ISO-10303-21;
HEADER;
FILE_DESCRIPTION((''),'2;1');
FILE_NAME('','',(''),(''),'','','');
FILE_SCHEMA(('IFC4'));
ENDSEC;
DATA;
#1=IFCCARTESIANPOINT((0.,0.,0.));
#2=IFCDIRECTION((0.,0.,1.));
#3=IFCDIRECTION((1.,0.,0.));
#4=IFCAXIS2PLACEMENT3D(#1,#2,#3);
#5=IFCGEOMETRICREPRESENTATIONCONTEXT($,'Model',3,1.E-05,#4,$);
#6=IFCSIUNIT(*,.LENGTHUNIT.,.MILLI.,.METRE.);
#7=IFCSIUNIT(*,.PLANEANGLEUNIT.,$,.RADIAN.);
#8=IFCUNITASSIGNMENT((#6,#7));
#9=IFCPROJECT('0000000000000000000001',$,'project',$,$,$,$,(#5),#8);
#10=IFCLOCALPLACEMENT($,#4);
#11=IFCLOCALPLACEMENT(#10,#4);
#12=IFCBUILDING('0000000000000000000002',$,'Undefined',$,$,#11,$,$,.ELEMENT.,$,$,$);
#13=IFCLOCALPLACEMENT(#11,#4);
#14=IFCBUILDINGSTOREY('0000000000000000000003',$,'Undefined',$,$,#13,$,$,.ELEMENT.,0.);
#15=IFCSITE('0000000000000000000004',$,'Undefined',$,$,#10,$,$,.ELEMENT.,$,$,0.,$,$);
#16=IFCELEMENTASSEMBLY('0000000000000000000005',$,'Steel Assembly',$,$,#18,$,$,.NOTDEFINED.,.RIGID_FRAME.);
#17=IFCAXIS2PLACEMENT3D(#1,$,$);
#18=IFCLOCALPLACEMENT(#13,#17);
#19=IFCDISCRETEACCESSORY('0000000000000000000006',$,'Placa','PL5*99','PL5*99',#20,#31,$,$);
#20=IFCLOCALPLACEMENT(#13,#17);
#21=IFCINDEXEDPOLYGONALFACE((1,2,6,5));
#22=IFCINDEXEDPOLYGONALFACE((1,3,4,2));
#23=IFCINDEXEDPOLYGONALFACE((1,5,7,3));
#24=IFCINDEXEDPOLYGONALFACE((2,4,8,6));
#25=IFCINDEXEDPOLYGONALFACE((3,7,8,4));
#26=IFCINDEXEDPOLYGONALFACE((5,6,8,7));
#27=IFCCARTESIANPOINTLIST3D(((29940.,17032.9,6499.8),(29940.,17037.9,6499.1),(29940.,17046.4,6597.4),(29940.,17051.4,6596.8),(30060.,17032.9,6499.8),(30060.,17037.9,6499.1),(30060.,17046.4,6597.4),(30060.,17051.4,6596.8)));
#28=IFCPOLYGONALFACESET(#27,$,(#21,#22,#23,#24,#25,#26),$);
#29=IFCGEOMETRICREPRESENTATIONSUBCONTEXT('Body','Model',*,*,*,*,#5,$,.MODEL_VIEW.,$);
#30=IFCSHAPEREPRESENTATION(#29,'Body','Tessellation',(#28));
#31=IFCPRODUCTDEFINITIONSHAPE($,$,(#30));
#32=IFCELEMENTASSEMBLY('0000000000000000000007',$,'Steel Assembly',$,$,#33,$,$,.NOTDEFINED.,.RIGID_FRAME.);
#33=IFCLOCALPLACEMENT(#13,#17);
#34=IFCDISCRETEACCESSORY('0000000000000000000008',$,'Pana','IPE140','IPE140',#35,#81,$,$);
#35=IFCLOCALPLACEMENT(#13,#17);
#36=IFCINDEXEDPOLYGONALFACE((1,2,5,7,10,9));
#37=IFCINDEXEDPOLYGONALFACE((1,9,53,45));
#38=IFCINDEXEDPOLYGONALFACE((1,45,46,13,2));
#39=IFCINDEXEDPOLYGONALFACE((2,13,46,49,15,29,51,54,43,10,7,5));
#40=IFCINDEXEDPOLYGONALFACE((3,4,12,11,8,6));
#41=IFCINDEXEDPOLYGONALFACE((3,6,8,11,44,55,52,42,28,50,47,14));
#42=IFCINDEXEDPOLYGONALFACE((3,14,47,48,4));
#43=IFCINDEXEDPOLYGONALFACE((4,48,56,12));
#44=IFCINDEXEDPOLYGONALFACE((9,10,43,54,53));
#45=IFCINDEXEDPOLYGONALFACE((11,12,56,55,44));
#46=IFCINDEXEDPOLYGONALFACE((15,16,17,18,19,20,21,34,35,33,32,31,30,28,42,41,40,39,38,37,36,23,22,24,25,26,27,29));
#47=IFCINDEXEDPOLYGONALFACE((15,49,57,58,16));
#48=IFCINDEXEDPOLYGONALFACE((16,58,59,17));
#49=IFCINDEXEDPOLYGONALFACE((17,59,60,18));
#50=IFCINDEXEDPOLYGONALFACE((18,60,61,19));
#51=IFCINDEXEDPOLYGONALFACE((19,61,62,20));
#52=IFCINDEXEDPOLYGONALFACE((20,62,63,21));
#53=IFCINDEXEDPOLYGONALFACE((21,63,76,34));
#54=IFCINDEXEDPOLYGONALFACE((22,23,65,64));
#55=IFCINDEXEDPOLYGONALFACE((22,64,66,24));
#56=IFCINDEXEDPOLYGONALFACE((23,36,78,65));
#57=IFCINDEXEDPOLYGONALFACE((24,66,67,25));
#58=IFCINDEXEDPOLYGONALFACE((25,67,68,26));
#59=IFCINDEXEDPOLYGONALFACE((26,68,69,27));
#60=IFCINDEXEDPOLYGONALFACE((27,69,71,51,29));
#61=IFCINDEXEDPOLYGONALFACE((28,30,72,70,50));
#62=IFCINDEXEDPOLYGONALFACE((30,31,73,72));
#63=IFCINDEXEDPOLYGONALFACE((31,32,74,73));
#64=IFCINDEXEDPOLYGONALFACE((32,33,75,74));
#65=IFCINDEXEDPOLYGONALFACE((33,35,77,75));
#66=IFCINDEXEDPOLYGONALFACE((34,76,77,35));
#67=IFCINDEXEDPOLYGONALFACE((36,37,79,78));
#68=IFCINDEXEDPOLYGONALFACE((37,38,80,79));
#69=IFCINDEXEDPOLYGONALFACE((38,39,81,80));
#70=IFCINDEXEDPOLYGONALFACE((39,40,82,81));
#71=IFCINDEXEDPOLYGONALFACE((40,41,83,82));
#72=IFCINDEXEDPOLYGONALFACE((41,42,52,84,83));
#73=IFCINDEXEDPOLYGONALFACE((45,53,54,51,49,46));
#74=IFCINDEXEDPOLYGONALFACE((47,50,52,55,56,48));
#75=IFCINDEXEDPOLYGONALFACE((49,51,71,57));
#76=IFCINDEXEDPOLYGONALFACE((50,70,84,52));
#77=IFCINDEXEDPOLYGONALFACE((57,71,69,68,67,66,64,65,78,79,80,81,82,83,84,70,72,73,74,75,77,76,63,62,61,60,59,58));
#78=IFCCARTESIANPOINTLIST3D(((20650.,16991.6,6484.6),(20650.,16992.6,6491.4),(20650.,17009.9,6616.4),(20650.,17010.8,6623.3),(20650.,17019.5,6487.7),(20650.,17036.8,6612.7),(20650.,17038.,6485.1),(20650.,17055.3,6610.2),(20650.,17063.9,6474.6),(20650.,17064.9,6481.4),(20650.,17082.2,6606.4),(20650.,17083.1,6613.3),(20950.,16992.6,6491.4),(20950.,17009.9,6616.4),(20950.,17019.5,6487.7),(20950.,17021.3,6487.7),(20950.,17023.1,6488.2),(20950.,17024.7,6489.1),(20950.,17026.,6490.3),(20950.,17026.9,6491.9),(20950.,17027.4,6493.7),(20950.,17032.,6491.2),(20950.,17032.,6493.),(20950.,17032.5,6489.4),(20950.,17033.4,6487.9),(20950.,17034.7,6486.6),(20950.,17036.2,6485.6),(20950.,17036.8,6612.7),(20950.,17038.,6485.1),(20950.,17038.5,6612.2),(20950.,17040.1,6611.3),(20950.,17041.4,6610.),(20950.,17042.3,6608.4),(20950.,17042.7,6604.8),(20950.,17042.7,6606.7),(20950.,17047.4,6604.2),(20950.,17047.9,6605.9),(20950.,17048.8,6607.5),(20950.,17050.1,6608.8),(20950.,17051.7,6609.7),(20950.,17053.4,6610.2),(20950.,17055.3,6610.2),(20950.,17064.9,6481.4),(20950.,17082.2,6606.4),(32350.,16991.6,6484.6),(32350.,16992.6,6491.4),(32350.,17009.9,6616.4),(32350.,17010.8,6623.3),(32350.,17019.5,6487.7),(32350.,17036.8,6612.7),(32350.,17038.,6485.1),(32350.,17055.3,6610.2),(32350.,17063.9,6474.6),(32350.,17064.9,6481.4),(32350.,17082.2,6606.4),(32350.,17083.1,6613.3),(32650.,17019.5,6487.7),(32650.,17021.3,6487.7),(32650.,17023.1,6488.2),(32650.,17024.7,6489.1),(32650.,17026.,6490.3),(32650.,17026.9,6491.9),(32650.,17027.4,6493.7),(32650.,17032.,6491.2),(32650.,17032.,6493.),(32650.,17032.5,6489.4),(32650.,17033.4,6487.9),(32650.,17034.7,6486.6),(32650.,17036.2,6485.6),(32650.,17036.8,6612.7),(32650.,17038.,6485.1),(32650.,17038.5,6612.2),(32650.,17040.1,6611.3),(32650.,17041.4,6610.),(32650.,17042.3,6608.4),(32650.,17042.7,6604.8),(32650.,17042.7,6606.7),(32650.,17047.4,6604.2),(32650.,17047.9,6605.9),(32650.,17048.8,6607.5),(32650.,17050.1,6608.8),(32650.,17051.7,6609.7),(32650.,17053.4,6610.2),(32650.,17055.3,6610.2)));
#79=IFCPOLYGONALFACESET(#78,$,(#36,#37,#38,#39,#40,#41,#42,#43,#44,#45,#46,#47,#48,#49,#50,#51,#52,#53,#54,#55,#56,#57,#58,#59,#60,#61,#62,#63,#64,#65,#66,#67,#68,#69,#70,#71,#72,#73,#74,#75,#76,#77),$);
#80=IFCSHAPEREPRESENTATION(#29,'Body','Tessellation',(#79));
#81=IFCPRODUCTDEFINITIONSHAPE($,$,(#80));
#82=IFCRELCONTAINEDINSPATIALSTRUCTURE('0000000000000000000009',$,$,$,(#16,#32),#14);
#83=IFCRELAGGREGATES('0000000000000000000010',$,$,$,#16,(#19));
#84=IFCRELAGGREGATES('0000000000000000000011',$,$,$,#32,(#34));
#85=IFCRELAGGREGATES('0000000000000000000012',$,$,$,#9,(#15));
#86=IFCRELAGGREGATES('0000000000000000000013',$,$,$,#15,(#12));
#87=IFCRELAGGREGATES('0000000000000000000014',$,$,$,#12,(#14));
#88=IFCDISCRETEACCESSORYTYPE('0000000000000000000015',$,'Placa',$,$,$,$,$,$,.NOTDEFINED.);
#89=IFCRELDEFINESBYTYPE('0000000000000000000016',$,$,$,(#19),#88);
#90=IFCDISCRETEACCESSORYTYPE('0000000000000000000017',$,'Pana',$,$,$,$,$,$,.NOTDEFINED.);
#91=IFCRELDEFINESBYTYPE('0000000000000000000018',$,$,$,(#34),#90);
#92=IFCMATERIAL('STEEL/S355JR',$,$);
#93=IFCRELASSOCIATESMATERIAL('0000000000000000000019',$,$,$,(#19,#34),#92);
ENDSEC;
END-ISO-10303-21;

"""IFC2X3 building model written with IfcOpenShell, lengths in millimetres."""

from ifc_helpers import new_model, si_unit, frame, origin_with_axes, origin_2d_with_axis, place, context, subcontext, project, spatial, polyline, i_section, outline, extrude, boolean, halfspace, material, type_object, element, aggregate, save


model = new_model("IFC2X3")

# Units and contexts
model_context = context("Model", 3, precision=1e-05, world=origin_with_axes())
body_context = subcontext(model_context, "Body", "Model", "MODEL_VIEW")
ifc_project = project(units=[si_unit("LENGTHUNIT", "METRE", prefix="MILLI"), si_unit("PLANEANGLEUNIT", "RADIAN")], contexts=[model_context])

# Site, building, storey
site_placement = place(None, origin_with_axes())
site = spatial("IfcSite", under=ifc_project, at=site_placement, Name="Undefined", CompositionType="ELEMENT", RefElevation=0.0)
building_placement = place(site_placement, origin_with_axes())
building = spatial("IfcBuilding", under=site, at=building_placement, Name="Undefined", CompositionType="ELEMENT")
storey_placement = place(building_placement, origin_with_axes())
storey = spatial("IfcBuildingStorey", under=building, at=storey_placement, Name="Undefined", CompositionType="ELEMENT", Elevation=0.0)

# Shared definitions
ifc_material_1 = material(Name="STEEL/S355JR")

# Element assembly
assembly_1_placement = place(storey_placement, origin_with_axes())
assembly_1 = element("IfcElementAssembly", 1, at=assembly_1_placement, inside=storey, Name="Steel Assembly", AssemblyPlace="NOTDEFINED", PredefinedType="RIGID_FRAME")

# Discrete accessory
discrete_accessory_type_1 = type_object("IfcDiscreteAccessoryType", Name="Placa")
discrete_accessory_1_placement = place(assembly_1_placement, frame((29940.0, 17035.4, 6499.4), z_axis=(0.0, 0.990592, -0.136849), x_axis=(0.0, 0.136849, 0.990592)))
discrete_accessory_1 = element("IfcDiscreteAccessory", 2, at=discrete_accessory_1_placement, type_object=discrete_accessory_type_1, material=ifc_material_1, Name="Placa", Description="PL5*99", ObjectType="PL5*99", context=body_context, shape_type="SweptSolid", body=[
    extrude(outline(polyline([(0.0, 0.0), (98.6, 0.0), (98.6, 120.0), (0.0, 120.0), (0.0, 0.0)])), frame((0.0, 0.0, -2.5), z_axis=(0.0, 0.0, 1.0), x_axis=(1.0, 0.0, 0.0)), (0.0, 0.0, 1.0), 5.0),
])

aggregate(assembly_1, [discrete_accessory_1])

# Element assembly, discrete accessory
discrete_accessory_type_2 = type_object("IfcDiscreteAccessoryType", Name="Pana")
assembly_2_placement = place(storey_placement, origin_with_axes())
assembly_2 = element("IfcElementAssembly", 3, at=assembly_2_placement, inside=storey, Name="Steel Assembly", AssemblyPlace="NOTDEFINED", PredefinedType="RIGID_FRAME")
discrete_accessory_2_placement = place(assembly_2_placement, frame((32650.0, 17037.4, 6548.9), z_axis=(0.0, 0.136926, 0.990581), x_axis=(-1.0, 0.0, 0.0)))
discrete_accessory_2 = element("IfcDiscreteAccessory", 4, at=discrete_accessory_2_placement, type_object=discrete_accessory_type_2, material=ifc_material_1, Name="Pana", Description="IPE140", ObjectType="IPE140", context=body_context, shape_type="CSG", body=[
    boolean("DIFFERENCE", boolean("DIFFERENCE", boolean("DIFFERENCE", boolean("DIFFERENCE", extrude(i_section(OverallWidth=73.0, OverallDepth=140.0, WebThickness=4.7, FlangeThickness=6.9, FilletRadius=7.0, at=origin_2d_with_axis()), frame((12005.0, 0.0, 0.0), z_axis=(-1.0, 0.0, 0.0), x_axis=(0.0, -1.0, 0.0)), (0.0, 0.0, 1.0), 12010.0), extrude(outline(polyline([(0.0, 0.0), (11.9, 0.0), (11.9, 300.0), (138.1, 300.0), (138.1, 0.0), (150.0, 0.0), (150.0, 305.0), (0.0, 305.0), (0.0, 0.0)])), frame((300.0, -41.5, 75.0), z_axis=(0.0, 1.0, 0.0), x_axis=(0.0, 0.0, -1.0)), (0.0, 0.0, 1.0), 83.0)), extrude(outline(polyline([(0.0, 0.0), (11.9, 0.0), (11.9, 5.0), (-138.1, 5.0), (-138.1, 0.0), (-126.2, 0.0), (-126.2, -300.0), (0.0, -300.0), (0.0, 0.0)])), frame((12000.0, -41.5, 63.1), z_axis=(0.0, 1.0, 0.0), x_axis=(0.0, 0.0, 1.0)), (0.0, 0.0, 1.0), 83.0)), halfspace(frame((12005.0, 0.0, 1070.0), z_axis=(1.0, 0.0, 0.0), x_axis=(0.0, 0.0, -1.0)), False)), halfspace(frame((-5.0, 0.0, 1070.0), z_axis=(1.0, 0.0, 0.0), x_axis=(0.0, 0.0, -1.0)), True)),
])
aggregate(assembly_2, [discrete_accessory_2])

save(model, "model.ifc")
